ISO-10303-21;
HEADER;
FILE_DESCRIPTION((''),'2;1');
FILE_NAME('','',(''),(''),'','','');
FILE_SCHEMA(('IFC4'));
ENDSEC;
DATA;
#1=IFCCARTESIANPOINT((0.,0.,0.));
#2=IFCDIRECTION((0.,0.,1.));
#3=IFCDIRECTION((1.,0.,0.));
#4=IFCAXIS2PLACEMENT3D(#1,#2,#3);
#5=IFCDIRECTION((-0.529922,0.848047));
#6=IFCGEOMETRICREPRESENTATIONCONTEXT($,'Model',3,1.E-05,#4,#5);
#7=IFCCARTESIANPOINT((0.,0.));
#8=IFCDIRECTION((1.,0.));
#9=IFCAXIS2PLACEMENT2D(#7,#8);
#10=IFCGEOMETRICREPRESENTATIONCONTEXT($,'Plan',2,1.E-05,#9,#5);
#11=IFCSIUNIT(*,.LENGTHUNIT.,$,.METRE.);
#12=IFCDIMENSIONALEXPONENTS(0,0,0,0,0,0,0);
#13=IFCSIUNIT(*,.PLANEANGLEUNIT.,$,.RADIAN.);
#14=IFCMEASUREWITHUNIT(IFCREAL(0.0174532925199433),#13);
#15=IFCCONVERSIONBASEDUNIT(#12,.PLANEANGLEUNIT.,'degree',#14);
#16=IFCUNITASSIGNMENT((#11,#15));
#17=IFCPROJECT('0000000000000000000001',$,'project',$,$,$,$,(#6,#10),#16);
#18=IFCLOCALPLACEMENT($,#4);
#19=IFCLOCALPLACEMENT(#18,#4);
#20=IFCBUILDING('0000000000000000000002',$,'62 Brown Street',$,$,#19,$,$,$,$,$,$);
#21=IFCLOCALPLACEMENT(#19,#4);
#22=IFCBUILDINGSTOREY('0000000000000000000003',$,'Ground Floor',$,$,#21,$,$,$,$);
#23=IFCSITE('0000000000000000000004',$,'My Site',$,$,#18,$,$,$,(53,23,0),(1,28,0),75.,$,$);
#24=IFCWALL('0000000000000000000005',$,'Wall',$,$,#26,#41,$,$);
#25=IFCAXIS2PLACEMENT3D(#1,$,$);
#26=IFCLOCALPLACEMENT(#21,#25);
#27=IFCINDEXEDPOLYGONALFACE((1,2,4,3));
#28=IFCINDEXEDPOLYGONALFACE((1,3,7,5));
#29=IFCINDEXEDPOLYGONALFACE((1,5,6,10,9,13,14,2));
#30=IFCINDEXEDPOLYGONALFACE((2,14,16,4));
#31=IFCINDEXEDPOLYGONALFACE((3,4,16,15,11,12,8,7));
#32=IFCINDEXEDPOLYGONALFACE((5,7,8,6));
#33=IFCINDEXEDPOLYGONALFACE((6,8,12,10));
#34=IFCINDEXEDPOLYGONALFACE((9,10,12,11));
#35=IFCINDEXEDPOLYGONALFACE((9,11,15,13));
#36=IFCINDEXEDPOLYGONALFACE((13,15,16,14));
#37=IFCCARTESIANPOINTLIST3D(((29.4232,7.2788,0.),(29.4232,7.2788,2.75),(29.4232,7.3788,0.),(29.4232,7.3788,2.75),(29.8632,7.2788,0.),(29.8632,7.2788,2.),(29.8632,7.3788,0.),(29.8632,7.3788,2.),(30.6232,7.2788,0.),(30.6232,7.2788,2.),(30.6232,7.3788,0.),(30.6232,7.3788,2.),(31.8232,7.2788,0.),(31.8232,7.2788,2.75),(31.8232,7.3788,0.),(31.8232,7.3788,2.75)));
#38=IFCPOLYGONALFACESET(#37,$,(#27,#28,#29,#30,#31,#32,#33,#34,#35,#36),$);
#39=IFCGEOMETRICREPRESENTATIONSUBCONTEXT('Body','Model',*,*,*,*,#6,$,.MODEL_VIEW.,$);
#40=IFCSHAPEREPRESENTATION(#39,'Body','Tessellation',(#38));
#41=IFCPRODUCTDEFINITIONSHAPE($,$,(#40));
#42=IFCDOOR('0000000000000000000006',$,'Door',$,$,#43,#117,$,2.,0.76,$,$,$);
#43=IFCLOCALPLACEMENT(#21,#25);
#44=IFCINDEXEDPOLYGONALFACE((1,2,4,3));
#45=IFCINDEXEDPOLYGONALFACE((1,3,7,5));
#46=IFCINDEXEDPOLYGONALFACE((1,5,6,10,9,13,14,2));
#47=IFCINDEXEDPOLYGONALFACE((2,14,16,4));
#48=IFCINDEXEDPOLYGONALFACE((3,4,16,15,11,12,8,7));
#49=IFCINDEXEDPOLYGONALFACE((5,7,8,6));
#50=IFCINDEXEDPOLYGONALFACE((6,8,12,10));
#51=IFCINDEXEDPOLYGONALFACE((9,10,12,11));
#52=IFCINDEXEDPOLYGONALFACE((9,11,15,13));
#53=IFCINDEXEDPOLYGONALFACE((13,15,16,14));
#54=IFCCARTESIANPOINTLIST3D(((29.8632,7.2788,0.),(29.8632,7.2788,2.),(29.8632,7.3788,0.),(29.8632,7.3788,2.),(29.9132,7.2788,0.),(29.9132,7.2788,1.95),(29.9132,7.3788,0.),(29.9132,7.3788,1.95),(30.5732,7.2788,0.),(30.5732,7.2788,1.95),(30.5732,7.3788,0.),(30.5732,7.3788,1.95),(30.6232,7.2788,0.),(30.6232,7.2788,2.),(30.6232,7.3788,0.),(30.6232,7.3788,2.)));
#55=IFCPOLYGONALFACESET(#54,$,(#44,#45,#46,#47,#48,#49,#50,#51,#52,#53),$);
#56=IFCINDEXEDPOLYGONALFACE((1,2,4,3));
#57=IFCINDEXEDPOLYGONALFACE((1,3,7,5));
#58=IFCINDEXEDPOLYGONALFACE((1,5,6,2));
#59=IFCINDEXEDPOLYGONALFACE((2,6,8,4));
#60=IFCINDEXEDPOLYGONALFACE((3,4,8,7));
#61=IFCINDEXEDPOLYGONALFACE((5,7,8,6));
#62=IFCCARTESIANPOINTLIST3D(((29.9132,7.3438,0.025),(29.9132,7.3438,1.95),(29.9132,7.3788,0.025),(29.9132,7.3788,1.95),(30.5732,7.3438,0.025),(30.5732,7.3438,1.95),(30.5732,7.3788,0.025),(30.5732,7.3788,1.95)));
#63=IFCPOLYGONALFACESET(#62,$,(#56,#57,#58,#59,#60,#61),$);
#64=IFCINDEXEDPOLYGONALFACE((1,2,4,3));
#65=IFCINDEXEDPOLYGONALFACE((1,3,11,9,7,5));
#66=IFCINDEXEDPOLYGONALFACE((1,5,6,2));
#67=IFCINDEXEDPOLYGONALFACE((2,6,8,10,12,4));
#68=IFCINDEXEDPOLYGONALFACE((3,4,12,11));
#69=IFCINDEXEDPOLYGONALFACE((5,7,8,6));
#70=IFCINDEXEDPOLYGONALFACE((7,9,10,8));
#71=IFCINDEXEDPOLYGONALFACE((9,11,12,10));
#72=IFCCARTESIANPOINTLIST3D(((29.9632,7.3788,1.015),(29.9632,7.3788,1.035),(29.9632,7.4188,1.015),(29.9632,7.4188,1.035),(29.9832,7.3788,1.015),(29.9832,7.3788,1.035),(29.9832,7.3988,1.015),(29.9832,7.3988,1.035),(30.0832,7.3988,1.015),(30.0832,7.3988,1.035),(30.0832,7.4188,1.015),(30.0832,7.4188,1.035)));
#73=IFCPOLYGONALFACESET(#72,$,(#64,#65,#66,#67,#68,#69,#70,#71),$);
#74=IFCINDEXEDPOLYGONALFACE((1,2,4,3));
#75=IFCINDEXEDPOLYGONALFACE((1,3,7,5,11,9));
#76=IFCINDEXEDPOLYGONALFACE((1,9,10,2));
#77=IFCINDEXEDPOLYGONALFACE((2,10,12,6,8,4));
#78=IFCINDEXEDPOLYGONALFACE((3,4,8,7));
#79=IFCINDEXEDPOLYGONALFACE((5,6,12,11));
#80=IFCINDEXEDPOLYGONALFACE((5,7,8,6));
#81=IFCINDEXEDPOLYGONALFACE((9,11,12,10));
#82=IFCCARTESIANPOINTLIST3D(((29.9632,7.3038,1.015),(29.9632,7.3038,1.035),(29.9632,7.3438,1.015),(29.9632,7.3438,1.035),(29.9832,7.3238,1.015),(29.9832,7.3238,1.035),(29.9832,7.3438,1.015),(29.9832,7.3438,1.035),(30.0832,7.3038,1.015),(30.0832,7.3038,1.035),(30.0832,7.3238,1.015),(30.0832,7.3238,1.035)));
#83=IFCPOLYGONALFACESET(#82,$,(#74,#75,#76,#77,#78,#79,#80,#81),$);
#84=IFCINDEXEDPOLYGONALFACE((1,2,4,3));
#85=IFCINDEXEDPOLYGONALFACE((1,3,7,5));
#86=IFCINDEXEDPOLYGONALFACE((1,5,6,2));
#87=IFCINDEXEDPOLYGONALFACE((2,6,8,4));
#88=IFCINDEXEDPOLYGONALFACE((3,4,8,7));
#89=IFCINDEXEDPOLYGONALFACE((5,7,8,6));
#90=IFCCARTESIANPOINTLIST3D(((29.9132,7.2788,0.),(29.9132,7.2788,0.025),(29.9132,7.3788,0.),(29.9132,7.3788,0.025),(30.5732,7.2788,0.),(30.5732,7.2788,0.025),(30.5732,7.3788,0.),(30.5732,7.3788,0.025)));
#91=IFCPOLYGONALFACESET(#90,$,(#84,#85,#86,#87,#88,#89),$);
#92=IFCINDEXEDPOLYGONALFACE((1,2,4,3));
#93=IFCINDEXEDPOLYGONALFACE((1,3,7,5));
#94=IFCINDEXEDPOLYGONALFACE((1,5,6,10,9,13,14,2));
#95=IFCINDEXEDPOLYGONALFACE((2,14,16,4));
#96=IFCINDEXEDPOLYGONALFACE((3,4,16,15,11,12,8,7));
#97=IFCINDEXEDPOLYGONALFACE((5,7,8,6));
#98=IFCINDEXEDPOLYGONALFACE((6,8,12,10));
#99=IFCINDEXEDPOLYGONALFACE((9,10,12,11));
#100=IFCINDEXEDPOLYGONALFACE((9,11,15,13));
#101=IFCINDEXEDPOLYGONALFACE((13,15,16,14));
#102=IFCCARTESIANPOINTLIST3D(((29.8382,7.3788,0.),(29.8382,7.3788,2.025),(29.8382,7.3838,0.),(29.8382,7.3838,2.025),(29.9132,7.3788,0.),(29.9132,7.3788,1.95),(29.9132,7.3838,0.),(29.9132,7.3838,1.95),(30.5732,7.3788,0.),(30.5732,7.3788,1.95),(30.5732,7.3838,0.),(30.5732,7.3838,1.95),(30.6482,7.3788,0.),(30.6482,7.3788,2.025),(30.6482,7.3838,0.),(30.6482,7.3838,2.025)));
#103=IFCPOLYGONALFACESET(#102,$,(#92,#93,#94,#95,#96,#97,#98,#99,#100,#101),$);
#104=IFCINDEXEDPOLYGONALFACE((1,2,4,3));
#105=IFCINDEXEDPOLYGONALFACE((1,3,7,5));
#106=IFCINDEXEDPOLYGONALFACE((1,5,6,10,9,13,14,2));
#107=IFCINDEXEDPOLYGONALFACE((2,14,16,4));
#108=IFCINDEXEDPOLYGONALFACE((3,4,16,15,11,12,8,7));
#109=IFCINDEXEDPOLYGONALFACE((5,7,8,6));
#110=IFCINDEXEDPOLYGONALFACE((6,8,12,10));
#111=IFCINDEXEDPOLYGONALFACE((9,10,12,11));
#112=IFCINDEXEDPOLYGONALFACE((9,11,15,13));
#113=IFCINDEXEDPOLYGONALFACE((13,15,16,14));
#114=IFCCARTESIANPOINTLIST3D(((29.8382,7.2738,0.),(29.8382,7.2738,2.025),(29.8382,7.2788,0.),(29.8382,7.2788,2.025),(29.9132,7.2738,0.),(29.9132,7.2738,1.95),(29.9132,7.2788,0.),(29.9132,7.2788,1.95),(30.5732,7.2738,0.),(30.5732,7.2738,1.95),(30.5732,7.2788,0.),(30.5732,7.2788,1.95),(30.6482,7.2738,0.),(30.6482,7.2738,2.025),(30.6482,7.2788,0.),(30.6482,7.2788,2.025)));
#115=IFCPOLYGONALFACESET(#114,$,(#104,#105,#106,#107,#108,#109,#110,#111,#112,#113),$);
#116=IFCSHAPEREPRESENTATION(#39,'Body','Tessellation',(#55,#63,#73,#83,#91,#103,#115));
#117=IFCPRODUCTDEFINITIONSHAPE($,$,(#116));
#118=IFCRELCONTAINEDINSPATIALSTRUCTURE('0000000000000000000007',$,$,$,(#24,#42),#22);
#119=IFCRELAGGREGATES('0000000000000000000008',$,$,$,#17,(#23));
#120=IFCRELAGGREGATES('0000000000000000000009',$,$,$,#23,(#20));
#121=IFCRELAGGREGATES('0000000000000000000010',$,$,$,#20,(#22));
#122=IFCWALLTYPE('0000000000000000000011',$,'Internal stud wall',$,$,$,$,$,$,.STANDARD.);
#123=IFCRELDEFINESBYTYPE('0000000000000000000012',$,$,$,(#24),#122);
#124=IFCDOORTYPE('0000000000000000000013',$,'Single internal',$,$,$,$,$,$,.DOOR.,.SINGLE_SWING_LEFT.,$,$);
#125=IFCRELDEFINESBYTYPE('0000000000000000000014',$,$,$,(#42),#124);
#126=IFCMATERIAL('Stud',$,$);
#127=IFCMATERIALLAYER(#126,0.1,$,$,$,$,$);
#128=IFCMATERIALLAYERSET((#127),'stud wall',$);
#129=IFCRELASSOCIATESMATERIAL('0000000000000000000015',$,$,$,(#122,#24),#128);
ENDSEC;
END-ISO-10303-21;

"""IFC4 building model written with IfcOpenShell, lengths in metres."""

from ifc_helpers import new_model, entity, si_unit, converted_unit, direction, frame, origin_with_axes, origin_2d_with_axis, place, context, subcontext, project, spatial, line, indexed_curve, outline, extrude, shape, source, transform, mapped, material, layer, layer_set, layer_usage, type_object, type_shapes, element, fill, save


model = new_model("IFC4")

# Units and contexts
model_context = context("Model", 3, precision=1e-05, world=origin_with_axes(), true_north=direction((-0.529922, 0.848047)))
plan_context = context("Plan", 2, precision=1e-05, world=origin_2d_with_axis(), true_north=direction((-0.529922, 0.848047)))
body_context_1 = subcontext(model_context, "Body", "Model", "MODEL_VIEW")
body_context_2 = subcontext(plan_context, "Body", "Plan", "PLAN_VIEW")
ifc_project = project(units=[si_unit("LENGTHUNIT", "METRE"), converted_unit("PLANEANGLEUNIT", "degree", entity("IfcReal", 0.0174532925199433), si_unit("PLANEANGLEUNIT", "RADIAN"), dimensions=[0, 0, 0, 0, 0, 0, 0])], contexts=[model_context, plan_context])

# Site, building, storey
site_placement = place(None, origin_with_axes())
site = spatial("IfcSite", under=ifc_project, at=site_placement, Name="My Site", RefLatitude=(53, 23, 0), RefLongitude=(1, 28, 0), RefElevation=75.0)
building_placement = place(site_placement, origin_with_axes())
building = spatial("IfcBuilding", under=site, at=building_placement, Name="62 Brown Street")
storey_placement = place(building_placement, origin_with_axes())
storey = spatial("IfcBuildingStorey", under=building, at=storey_placement, Name="Ground Floor")

# Wall, opening, door
ifc_material_1 = material(Name="Stud")
ifc_layer_1 = layer(ifc_material_1, 0.1)
ifc_layer_set_1 = layer_set([ifc_layer_1], Name="stud wall")
ifc_layer_usage_1 = layer_usage(ifc_layer_set_1, "AXIS2", "POSITIVE", 0.0)
wall_type_1 = type_object("IfcWallType", Name="Internal stud wall", PredefinedType="STANDARD", material=ifc_layer_set_1)
wall_1_placement = place(storey_placement, frame((31.8232, 7.3788, 0.0), z_axis=(0.0, 0.0, 1.0), x_axis=(-1.0, 0.0, 0.0)))
wall_1 = element("IfcWall", 1, at=wall_1_placement, inside=storey, type_object=wall_type_1, material=ifc_layer_usage_1, Name="Wall", context=body_context_1, shape_type="SweptSolid", body=[
    extrude(outline(indexed_curve([(0.0, 0.0), (0.0, 0.1), (2.4, 0.1), (2.4, 0.0), (0.0, 0.0)], self_intersect=False)), origin_with_axes(), (0.0, 0.0, 1.0), 2.75),
])
shared_shape_1 = source(origin_with_axes(), body_context_1, "Body", "SweptSolid", [
    extrude(outline(indexed_curve([(0.0, 0.0), (0.76, 0.0), (0.76, 2.0), (0.0, 2.0)], segments=[line(1, 2, 3, 4, 1)])), frame((0.0, -0.6, 0.0), z_axis=(0.0, -1.0, 0.0), x_axis=(1.0, 0.0, 0.0)), (0.0, 0.0, -1.0), 1.2),
])
opening_1_placement = place(wall_1_placement, frame((1.2, 0.0, 0.0), z_axis=(0.0, 0.0, 1.0), x_axis=(1.0, 0.0, 0.0)))
opening_1 = element("IfcOpeningElement", 2, at=opening_1_placement, cuts=wall_1, PredefinedType="OPENING", context=body_context_1, shape_type="MappedRepresentation", body=[
    mapped(shared_shape_1, transform((0.0, 0.0, 0.0), x_axis=(1.0, 0.0, 0.0), y_axis=(0.0, 1.0, 0.0), z_axis=(0.0, 0.0, 1.0), scale=1.0)),
])
door_type_1 = type_object("IfcDoorType", Name="Single internal", OperationType="SINGLE_SWING_LEFT", PredefinedType="DOOR")
shared_shape_2 = source(origin_with_axes(), body_context_1, "Body", "SweptSolid", [
    extrude(outline(indexed_curve([(0.0, 0.0), (0.0, 2.0), (0.76, 2.0), (0.76, 0.0), (0.71, 0.0), (0.71, 1.95), (0.05, 1.95), (0.05, 0.0)], segments=[line(1, 2, 3, 4, 5, 6, 7, 8, 1)])), frame((0.0, 0.0, 0.0), z_axis=(0.0, -1.0, 0.0), x_axis=(1.0, 0.0, 0.0)), (0.0, 0.0, -1.0), 0.1),
    extrude(outline(indexed_curve([(0.0, 0.0), (0.66, 0.0), (0.66, 0.035), (0.0, 0.035)], segments=[line(1, 2, 3, 4, 1)])), frame((0.05, 0.0, 0.025), z_axis=(0.0, 0.0, 1.0), x_axis=(1.0, 0.0, 0.0)), (0.0, 0.0, 1.0), 1.925),
    extrude(outline(indexed_curve([(0.0, 0.0), (0.0, -0.04), (-0.12, -0.04), (-0.12, -0.02), (-0.02, -0.02), (-0.02, 0.0)], segments=[line(1, 2, 3, 4, 5, 6, 1)])), frame((0.66, 0.0, 1.015), z_axis=(0.0, 0.0, 1.0), x_axis=(1.0, 0.0, 0.0)), (0.0, 0.0, 1.0), 0.02),
    extrude(outline(indexed_curve([(0.0, 0.0), (0.0, 0.04), (-0.12, 0.04), (-0.12, 0.02), (-0.02, 0.02), (-0.02, 0.0)], segments=[line(1, 2, 3, 4, 5, 6, 1)])), frame((0.66, 0.035, 1.015), z_axis=(0.0, 0.0, 1.0), x_axis=(1.0, 0.0, 0.0)), (0.0, 0.0, 1.0), 0.02),
    extrude(outline(indexed_curve([(0.0, 0.0), (0.66, 0.0), (0.66, 0.1), (0.0, 0.1)], segments=[line(1, 2, 3, 4, 1)])), frame((0.05, 0.0, 0.0), z_axis=(0.0, 0.0, 1.0), x_axis=(1.0, 0.0, 0.0)), (0.0, 0.0, 1.0), 0.025),
    extrude(outline(indexed_curve([(0.0, 0.0), (0.0, 2.025), (0.81, 2.025), (0.81, 0.0), (0.735, 0.0), (0.735, 1.95), (0.075, 1.95), (0.075, 0.0)], segments=[line(1, 2, 3, 4, 5, 6, 7, 8, 1)])), frame((-0.025, -0.005, 0.0), z_axis=(0.0, -1.0, 0.0), x_axis=(1.0, 0.0, 0.0)), (0.0, 0.0, -1.0), 0.005),
    extrude(outline(indexed_curve([(0.0, 0.0), (0.0, 2.025), (0.81, 2.025), (0.81, 0.0), (0.735, 0.0), (0.735, 1.95), (0.075, 1.95), (0.075, 0.0)], segments=[line(1, 2, 3, 4, 5, 6, 7, 8, 1)])), frame((-0.025, 0.1, 0.0), z_axis=(0.0, -1.0, 0.0), x_axis=(1.0, 0.0, 0.0)), (0.0, 0.0, -1.0), 0.005),
])
shared_shape_3 = source(origin_with_axes(), body_context_2, "Body", "Curve2D", [
    entity("IfcIndexedPolyCurve", entity("IfcCartesianPointList2D", [[0.0, 0.0], [0.05, 0.0], [0.05, 0.1], [0.0, 0.1]]), [entity("IfcLineIndex", [1, 2, 3, 4, 1])]),
    entity("IfcIndexedPolyCurve", entity("IfcCartesianPointList2D", [[0.76, 0.0], [0.71, 0.0], [0.71, 0.1], [0.76, 0.1]]), [entity("IfcLineIndex", [1, 2, 3, 4, 1])]),
    entity("IfcTrimmedCurve", entity("IfcEllipse", entity("IfcAxis2Placement2D", entity("IfcCartesianPoint", [0.085, 0.1]), entity("IfcDirection", [1.0, 0.0])), 0.625, 0.66), [entity("IfcCartesianPoint", [0.71, 0.1])], [entity("IfcCartesianPoint", [0.085, 0.76])], True, "CARTESIAN"),
    entity("IfcIndexedPolyCurve", entity("IfcCartesianPointList2D", [[0.05, 0.1], [0.085, 0.1], [0.085, 0.76], [0.05, 0.76]]), [entity("IfcLineIndex", [1, 2, 3, 4, 1])]),
])
type_shapes(door_type_1, [shared_shape_2, shared_shape_3])
door_1_placement = place(opening_1_placement, frame((0.0, 0.0, 0.0), z_axis=(0.0, 0.0, 1.0), x_axis=(1.0, 0.0, 0.0)))
door_1 = element("IfcDoor", 3, at=door_1_placement, inside=storey, type_object=door_type_1, Name="Door", OverallHeight=2.0, OverallWidth=0.76, shapes=[
    shape(body_context_1, "Body", "MappedRepresentation", [mapped(shared_shape_2, transform((0.0, 0.0, 0.0), x_axis=(1.0, 0.0, 0.0), y_axis=(0.0, 1.0, 0.0), z_axis=(0.0, 0.0, 1.0), scale=1.0))]),
    shape(body_context_2, "Body", "MappedRepresentation", [mapped(shared_shape_3, transform((0.0, 0.0, 0.0), x_axis=(1.0, 0.0, 0.0), y_axis=(0.0, 1.0, 0.0), z_axis=(0.0, 0.0, 1.0), scale=1.0))]),
])
fill(opening_1, door_1)

save(model, "model.ifc")
